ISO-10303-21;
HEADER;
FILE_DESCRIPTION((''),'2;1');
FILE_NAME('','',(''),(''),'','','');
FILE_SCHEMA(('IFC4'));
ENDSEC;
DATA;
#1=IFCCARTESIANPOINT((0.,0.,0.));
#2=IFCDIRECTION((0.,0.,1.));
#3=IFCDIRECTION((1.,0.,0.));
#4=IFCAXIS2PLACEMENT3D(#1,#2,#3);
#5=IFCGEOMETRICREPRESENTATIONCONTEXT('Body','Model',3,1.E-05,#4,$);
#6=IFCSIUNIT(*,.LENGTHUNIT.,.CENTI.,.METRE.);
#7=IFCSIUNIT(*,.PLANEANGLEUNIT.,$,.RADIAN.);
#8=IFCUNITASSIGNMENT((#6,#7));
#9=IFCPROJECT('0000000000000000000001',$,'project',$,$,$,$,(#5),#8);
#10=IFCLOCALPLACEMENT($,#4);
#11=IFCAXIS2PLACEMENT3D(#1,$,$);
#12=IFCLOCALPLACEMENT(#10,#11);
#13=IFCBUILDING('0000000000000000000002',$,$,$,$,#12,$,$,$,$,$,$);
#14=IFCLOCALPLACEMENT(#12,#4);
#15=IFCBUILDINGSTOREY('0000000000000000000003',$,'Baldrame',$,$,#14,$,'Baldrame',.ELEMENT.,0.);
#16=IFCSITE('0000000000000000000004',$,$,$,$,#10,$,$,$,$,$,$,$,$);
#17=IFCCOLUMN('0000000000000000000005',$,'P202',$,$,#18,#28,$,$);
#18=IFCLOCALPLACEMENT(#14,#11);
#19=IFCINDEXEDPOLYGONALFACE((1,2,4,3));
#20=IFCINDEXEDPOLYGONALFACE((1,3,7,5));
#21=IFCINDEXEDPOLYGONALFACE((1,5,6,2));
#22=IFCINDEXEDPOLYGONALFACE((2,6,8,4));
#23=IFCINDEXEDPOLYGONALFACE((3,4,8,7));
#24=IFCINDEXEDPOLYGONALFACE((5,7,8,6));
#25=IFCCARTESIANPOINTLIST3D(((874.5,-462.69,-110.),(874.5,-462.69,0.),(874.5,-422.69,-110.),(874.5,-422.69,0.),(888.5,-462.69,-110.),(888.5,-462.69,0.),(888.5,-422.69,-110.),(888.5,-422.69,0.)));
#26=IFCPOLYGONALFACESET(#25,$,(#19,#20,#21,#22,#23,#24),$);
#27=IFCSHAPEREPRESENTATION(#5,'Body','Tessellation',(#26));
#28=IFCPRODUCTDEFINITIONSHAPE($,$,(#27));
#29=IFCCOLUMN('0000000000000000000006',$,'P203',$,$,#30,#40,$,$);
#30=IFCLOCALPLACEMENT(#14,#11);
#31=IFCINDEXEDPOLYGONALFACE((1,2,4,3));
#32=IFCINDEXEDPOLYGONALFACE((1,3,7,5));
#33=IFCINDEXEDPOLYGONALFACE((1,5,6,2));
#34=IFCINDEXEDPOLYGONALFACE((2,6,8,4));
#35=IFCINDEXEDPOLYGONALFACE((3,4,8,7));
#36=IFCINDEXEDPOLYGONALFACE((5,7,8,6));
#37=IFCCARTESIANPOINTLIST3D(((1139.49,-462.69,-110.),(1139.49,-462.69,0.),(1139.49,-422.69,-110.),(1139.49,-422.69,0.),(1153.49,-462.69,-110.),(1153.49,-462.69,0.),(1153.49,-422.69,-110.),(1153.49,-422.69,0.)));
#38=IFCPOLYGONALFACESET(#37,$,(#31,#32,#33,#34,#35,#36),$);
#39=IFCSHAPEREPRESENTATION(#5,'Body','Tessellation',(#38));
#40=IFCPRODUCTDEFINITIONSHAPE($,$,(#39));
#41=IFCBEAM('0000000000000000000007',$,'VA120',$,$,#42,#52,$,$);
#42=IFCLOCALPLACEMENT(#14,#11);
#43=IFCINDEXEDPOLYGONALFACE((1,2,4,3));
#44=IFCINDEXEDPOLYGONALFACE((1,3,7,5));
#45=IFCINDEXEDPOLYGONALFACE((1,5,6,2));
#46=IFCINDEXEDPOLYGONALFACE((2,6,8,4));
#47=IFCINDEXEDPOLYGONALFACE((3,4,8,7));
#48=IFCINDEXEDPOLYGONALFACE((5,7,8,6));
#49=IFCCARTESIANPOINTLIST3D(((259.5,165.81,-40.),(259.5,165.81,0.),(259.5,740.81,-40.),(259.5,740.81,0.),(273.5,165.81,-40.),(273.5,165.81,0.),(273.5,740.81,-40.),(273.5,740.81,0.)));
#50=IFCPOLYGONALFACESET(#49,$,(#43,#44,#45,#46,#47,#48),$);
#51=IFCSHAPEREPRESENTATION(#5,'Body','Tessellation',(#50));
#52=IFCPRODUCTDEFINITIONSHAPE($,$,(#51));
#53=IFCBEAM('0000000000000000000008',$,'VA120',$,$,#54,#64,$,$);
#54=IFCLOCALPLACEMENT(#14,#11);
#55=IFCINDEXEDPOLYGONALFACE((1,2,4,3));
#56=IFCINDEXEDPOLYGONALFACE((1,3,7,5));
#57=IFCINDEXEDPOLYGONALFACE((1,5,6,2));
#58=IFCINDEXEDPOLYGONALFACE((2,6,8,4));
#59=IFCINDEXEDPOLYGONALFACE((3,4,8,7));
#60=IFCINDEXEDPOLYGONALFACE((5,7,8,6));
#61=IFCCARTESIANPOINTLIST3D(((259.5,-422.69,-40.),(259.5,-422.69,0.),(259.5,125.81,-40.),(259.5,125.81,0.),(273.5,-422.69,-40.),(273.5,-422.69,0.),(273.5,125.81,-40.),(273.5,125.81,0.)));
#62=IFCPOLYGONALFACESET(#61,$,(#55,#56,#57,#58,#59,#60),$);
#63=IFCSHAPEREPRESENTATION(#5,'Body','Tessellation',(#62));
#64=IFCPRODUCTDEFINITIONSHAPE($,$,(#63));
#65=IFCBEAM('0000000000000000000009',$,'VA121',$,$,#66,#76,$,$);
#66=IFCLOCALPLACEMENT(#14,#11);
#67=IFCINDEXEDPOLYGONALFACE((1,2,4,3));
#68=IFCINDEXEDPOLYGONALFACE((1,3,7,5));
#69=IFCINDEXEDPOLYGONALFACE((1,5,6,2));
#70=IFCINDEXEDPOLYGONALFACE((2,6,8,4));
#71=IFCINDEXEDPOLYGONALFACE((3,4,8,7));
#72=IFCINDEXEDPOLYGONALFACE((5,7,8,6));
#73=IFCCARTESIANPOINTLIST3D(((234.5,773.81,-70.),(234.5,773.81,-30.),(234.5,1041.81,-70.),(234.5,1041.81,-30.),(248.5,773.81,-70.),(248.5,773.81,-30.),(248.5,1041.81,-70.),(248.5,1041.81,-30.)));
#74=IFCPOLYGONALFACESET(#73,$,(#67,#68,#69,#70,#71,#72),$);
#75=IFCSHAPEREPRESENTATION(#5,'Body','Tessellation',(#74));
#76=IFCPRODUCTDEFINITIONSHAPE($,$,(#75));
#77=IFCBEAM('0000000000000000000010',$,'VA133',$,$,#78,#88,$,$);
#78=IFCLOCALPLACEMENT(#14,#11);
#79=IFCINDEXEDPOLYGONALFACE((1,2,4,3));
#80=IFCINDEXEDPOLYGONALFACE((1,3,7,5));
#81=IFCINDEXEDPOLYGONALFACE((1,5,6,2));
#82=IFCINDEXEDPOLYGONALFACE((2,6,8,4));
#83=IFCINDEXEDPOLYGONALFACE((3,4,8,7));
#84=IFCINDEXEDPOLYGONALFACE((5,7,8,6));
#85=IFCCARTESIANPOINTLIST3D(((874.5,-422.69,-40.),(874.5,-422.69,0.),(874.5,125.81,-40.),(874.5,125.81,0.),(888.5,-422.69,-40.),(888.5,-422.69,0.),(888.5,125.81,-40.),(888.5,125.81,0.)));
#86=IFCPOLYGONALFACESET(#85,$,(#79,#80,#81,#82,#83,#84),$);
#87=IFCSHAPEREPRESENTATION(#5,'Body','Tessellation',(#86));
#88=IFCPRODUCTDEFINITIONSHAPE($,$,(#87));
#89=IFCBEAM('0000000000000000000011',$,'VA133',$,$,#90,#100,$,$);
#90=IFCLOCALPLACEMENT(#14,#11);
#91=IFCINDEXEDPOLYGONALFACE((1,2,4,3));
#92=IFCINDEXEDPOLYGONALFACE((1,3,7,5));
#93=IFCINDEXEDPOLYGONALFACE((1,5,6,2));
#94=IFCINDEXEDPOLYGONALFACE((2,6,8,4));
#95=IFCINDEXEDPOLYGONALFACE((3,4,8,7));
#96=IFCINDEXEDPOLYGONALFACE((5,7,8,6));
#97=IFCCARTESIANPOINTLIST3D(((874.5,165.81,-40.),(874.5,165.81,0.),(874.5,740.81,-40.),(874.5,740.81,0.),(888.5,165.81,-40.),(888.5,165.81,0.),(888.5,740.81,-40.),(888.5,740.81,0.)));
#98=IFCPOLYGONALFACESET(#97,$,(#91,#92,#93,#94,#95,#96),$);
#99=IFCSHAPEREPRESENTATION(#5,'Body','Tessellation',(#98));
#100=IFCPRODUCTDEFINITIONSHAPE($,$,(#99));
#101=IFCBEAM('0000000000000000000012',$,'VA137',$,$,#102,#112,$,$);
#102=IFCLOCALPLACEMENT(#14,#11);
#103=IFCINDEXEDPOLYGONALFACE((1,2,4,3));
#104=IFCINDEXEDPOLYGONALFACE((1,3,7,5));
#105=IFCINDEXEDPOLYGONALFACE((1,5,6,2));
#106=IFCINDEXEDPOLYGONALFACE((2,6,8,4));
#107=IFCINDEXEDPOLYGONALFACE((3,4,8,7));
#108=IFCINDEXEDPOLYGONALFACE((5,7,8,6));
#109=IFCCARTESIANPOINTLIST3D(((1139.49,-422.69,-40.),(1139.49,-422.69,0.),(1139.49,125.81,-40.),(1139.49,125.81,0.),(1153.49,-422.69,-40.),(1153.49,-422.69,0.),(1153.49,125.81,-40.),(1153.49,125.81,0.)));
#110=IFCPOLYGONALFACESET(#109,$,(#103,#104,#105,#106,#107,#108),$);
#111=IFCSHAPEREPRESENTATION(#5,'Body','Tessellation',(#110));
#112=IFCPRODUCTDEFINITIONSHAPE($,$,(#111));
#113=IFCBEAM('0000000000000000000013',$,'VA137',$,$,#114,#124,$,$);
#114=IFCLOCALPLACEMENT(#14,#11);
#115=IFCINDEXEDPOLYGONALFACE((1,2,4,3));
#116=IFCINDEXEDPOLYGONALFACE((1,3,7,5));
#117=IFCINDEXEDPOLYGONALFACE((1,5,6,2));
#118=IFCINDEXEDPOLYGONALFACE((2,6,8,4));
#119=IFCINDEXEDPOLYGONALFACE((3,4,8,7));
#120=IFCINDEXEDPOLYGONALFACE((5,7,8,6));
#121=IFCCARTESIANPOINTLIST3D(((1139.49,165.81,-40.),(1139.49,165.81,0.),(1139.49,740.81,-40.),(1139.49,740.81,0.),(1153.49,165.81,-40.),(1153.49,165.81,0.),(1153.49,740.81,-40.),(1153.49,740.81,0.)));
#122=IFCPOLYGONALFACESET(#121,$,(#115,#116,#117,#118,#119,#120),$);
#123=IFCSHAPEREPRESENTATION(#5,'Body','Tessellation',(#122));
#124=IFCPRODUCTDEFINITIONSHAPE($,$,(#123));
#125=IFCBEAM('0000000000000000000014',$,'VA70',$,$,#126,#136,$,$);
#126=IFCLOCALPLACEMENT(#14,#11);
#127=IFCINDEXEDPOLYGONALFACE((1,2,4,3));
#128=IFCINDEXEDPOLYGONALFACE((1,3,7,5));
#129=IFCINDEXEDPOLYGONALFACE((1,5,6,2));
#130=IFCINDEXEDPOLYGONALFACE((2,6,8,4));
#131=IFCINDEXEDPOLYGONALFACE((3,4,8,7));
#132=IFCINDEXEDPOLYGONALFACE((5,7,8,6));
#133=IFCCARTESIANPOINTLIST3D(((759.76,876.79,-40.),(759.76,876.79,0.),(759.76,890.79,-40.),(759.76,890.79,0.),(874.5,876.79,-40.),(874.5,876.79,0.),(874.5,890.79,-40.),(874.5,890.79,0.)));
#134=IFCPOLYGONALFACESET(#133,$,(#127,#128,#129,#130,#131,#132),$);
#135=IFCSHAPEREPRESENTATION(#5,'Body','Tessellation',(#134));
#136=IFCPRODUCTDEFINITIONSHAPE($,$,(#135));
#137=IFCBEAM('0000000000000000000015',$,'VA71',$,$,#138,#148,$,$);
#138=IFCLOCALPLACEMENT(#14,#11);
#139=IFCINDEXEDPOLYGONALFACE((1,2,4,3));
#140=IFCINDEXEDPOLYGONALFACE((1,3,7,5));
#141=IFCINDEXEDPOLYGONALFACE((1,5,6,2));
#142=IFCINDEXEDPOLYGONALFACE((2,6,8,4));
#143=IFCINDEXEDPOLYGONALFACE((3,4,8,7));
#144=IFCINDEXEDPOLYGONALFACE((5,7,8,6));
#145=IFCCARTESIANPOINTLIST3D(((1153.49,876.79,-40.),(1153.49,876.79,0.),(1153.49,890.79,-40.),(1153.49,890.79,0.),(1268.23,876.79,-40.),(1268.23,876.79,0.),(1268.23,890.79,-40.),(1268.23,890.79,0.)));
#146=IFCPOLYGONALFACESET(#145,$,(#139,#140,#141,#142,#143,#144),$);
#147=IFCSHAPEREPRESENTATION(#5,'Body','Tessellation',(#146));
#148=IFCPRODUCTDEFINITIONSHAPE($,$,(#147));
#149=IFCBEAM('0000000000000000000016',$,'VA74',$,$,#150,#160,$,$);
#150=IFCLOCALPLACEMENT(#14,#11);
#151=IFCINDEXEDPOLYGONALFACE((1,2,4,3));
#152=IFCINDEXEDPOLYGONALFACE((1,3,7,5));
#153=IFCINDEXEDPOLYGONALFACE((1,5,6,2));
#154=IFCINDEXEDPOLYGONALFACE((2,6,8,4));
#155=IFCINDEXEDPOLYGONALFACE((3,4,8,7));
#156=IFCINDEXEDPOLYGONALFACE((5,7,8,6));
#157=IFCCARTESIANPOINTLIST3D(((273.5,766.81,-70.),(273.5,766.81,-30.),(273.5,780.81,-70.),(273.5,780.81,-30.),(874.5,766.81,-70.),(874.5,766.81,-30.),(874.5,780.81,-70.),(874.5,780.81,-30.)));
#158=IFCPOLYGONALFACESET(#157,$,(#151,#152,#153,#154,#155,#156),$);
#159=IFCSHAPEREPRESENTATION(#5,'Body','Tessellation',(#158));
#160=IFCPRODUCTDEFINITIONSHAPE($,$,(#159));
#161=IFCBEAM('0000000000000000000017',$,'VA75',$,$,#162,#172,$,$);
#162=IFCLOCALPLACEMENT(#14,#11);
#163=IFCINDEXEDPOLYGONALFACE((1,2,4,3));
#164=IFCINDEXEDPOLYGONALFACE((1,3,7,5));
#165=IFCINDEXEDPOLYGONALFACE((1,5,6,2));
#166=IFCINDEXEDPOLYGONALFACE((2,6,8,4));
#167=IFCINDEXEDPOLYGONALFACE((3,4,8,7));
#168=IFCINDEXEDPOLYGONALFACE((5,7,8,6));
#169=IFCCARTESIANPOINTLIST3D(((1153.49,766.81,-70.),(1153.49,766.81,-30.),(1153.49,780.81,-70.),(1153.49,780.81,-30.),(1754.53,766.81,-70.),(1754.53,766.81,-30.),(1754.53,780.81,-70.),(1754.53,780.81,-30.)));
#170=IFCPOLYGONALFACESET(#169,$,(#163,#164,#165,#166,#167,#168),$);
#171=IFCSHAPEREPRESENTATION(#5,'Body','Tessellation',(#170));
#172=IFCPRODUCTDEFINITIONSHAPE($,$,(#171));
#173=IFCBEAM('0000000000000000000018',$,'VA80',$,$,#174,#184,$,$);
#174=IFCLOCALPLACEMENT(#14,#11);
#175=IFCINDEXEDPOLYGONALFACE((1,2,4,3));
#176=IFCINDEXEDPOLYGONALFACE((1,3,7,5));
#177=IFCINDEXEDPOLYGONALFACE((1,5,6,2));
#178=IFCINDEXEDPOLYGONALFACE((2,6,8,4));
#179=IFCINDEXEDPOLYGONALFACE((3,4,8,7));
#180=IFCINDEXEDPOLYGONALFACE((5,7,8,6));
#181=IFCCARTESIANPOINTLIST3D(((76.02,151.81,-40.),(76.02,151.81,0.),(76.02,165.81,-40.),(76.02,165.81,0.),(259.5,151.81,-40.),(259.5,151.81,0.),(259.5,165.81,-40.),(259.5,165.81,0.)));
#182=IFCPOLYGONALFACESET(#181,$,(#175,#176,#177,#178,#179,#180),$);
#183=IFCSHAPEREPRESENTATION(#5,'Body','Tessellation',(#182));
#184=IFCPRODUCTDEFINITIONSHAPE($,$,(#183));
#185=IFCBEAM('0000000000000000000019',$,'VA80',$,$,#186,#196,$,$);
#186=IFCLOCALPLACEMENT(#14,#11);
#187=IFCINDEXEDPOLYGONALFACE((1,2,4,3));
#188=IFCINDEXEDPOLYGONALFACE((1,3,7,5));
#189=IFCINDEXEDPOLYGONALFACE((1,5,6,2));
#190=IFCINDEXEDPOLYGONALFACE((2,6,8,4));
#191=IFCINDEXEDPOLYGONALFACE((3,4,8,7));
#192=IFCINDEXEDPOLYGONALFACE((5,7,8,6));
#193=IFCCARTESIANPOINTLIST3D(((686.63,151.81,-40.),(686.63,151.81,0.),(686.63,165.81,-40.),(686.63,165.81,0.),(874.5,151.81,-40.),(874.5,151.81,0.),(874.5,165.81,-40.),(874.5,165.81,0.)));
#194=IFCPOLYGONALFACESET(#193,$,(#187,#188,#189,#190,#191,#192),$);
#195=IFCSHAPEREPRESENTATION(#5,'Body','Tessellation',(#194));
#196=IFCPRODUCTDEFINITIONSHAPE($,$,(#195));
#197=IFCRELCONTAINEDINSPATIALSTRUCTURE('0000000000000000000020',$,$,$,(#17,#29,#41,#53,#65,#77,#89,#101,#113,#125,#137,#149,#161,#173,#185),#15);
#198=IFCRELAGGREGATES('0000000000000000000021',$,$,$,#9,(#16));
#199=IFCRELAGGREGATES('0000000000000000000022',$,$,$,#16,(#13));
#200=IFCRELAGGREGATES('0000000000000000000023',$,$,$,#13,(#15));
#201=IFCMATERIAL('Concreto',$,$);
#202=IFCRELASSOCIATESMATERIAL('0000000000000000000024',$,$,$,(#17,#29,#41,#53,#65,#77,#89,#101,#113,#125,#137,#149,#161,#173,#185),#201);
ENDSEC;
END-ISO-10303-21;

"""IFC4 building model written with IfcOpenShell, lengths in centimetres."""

from ifc_helpers import new_model, si_unit, frame, origin, origin_with_axes, origin_2d_with_axis, place, context, project, spatial, rectangle, extrude, material, element, save


model = new_model("IFC4")

# Units and contexts
model_context = context("Model", 3, precision=1e-05, world=origin_with_axes(), identifier="Body")
ifc_project = project(units=[si_unit("LENGTHUNIT", "METRE", prefix="CENTI"), si_unit("PLANEANGLEUNIT", "RADIAN")], contexts=[model_context])

# Site, building, storey
site_placement = place(None, origin_with_axes())
site = spatial("IfcSite", under=ifc_project, at=site_placement)
building_placement = place(site_placement, origin())
building = spatial("IfcBuilding", under=site, at=building_placement)
storey_placement = place(building_placement, origin_with_axes())
storey = spatial("IfcBuildingStorey", under=building, at=storey_placement, Name="Baldrame", LongName="Baldrame", CompositionType="ELEMENT", Elevation=0.0)

# Shared definitions
ifc_material = material(Name="Concreto")

# Columns
for number, where, z_axis, x_axis, name in (
    (1, (881.5, -442.69, 0.0), (0.0, 0.0, 1.0), (1.0, 0.0, 0.0), "P202"),
    (2, (1146.49, -442.69, 0.0), (0.0, 0.0, 1.0), (1.0, 0.0, 0.0), "P203"),
):
    element("IfcColumn", number, at=place(storey_placement, frame(where, z_axis=z_axis, x_axis=x_axis)), inside=storey, material=ifc_material, Name=name, context=model_context, shape_type="SolidModel", body=[
        extrude(rectangle(XDim=14.0, YDim=40.0, at=origin_2d_with_axis()), frame((0.0, 0.0, -110.0), z_axis=(0.0, 0.0, 1.0), x_axis=(1.0, 0.0, 0.0)), (0.0, 0.0, 1.0), 110.0),
    ])

# Beams
beam_1_placement = place(storey_placement, frame((266.5, 453.31, 0.0), z_axis=(0.0, 0.0, 1.0), x_axis=(1.0, 0.0, 0.0)))
element("IfcBeam", 3, at=beam_1_placement, inside=storey, material=ifc_material, Name="VA120", context=model_context, shape_type="SolidModel", body=[
    extrude(rectangle(XDim=14.0, YDim=40.0, at=origin_2d_with_axis()), frame((0.0, -287.5, -20.0), z_axis=(0.0, 1.0, 0.0), x_axis=(1.0, 0.0, 0.0)), (0.0, 0.0, 1.0), 575.0),
])
beam_2_placement = place(storey_placement, frame((266.5, -148.44, 0.0), z_axis=(0.0, 0.0, 1.0), x_axis=(1.0, 0.0, 0.0)))
element("IfcBeam", 4, at=beam_2_placement, inside=storey, material=ifc_material, Name="VA120", context=model_context, shape_type="SolidModel", body=[
    extrude(rectangle(XDim=14.0, YDim=40.0, at=origin_2d_with_axis()), frame((0.0, -274.25, -20.0), z_axis=(0.0, 1.0, 0.0), x_axis=(1.0, 0.0, 0.0)), (0.0, 0.0, 1.0), 548.5),
])
beam_3_placement = place(storey_placement, frame((241.5, 907.81, -30.0), z_axis=(0.0, 0.0, 1.0), x_axis=(1.0, 0.0, 0.0)))
element("IfcBeam", 5, at=beam_3_placement, inside=storey, material=ifc_material, Name="VA121", context=model_context, shape_type="SolidModel", body=[
    extrude(rectangle(XDim=14.0, YDim=40.0, at=origin_2d_with_axis()), frame((0.0, -134.0, -20.0), z_axis=(0.0, 1.0, 0.0), x_axis=(-1.0, 0.0, 0.0)), (0.0, 0.0, 1.0), 268.0),
])
beam_4_placement = place(storey_placement, frame((881.5, -148.44, 0.0), z_axis=(0.0, 0.0, 1.0), x_axis=(1.0, 0.0, 0.0)))
element("IfcBeam", 6, at=beam_4_placement, inside=storey, material=ifc_material, Name="VA133", context=model_context, shape_type="SolidModel", body=[
    extrude(rectangle(XDim=14.0, YDim=40.0, at=origin_2d_with_axis()), frame((0.0, -274.25, -20.0), z_axis=(0.0, 1.0, 0.0), x_axis=(1.0, 0.0, 0.0)), (0.0, 0.0, 1.0), 548.5),
])
beam_5_placement = place(storey_placement, frame((881.5, 453.31, 0.0), z_axis=(0.0, 0.0, 1.0), x_axis=(1.0, 0.0, 0.0)))
element("IfcBeam", 7, at=beam_5_placement, inside=storey, material=ifc_material, Name="VA133", context=model_context, shape_type="SolidModel", body=[
    extrude(rectangle(XDim=14.0, YDim=40.0, at=origin_2d_with_axis()), frame((0.0, -287.5, -20.0), z_axis=(0.0, 1.0, 0.0), x_axis=(1.0, 0.0, 0.0)), (0.0, 0.0, 1.0), 575.0),
])
beam_6_placement = place(storey_placement, frame((1146.49, -148.44, 0.0), z_axis=(0.0, 0.0, 1.0), x_axis=(1.0, 0.0, 0.0)))
element("IfcBeam", 8, at=beam_6_placement, inside=storey, material=ifc_material, Name="VA137", context=model_context, shape_type="SolidModel", body=[
    extrude(rectangle(XDim=14.0, YDim=40.0, at=origin_2d_with_axis()), frame((0.0, -274.25, -20.0), z_axis=(0.0, 1.0, 0.0), x_axis=(1.0, 0.0, 0.0)), (0.0, 0.0, 1.0), 548.5),
])
beam_7_placement = place(storey_placement, frame((1146.49, 453.31, 0.0), z_axis=(0.0, 0.0, 1.0), x_axis=(1.0, 0.0, 0.0)))
element("IfcBeam", 9, at=beam_7_placement, inside=storey, material=ifc_material, Name="VA137", context=model_context, shape_type="SolidModel", body=[
    extrude(rectangle(XDim=14.0, YDim=40.0, at=origin_2d_with_axis()), frame((0.0, -287.5, -20.0), z_axis=(0.0, 1.0, 0.0), x_axis=(1.0, 0.0, 0.0)), (0.0, 0.0, 1.0), 575.0),
])
beam_8_placement = place(storey_placement, frame((817.13, 883.79, 0.0), z_axis=(0.0, 0.0, 1.0), x_axis=(1.0, 0.0, 0.0)))
element("IfcBeam", 10, at=beam_8_placement, inside=storey, material=ifc_material, Name="VA70", context=model_context, shape_type="SolidModel", body=[
    extrude(rectangle(XDim=14.0, YDim=40.0, at=origin_2d_with_axis()), frame((-57.37, 0.0, -20.0), z_axis=(1.0, 0.0, 0.0), x_axis=(0.0, 1.0, 0.0)), (0.0, 0.0, 1.0), 114.74),
])
beam_9_placement = place(storey_placement, frame((1210.86, 883.79, 0.0), z_axis=(0.0, 0.0, 1.0), x_axis=(1.0, 0.0, 0.0)))
element("IfcBeam", 11, at=beam_9_placement, inside=storey, material=ifc_material, Name="VA71", context=model_context, shape_type="SolidModel", body=[
    extrude(rectangle(XDim=14.0, YDim=40.0, at=origin_2d_with_axis()), frame((-57.37, 0.0, -20.0), z_axis=(1.0, 0.0, 0.0), x_axis=(0.0, 1.0, 0.0)), (0.0, 0.0, 1.0), 114.74),
])
beam_10_placement = place(storey_placement, frame((574.0, 773.81, -30.0), z_axis=(0.0, 0.0, 1.0), x_axis=(1.0, 0.0, 0.0)))
element("IfcBeam", 12, at=beam_10_placement, inside=storey, material=ifc_material, Name="VA74", context=model_context, shape_type="SolidModel", body=[
    extrude(rectangle(XDim=14.0, YDim=40.0, at=origin_2d_with_axis()), frame((-300.5, 0.0, -20.0), z_axis=(1.0, 0.0, 0.0), x_axis=(0.0, 1.0, 0.0)), (0.0, 0.0, 1.0), 601.0),
])
beam_11_placement = place(storey_placement, frame((1454.01, 773.81, -30.0), z_axis=(0.0, 0.0, 1.0), x_axis=(1.0, 0.0, 0.0)))
element("IfcBeam", 13, at=beam_11_placement, inside=storey, material=ifc_material, Name="VA75", context=model_context, shape_type="SolidModel", body=[
    extrude(rectangle(XDim=14.0, YDim=40.0, at=origin_2d_with_axis()), frame((-300.52, 0.0, -20.0), z_axis=(1.0, 0.0, 0.0), x_axis=(0.0, 1.0, 0.0)), (0.0, 0.0, 1.0), 601.04),
])
beam_12_placement = place(storey_placement, frame((167.76, 158.81, 0.0), z_axis=(0.0, 0.0, 1.0), x_axis=(1.0, 0.0, 0.0)))
element("IfcBeam", 14, at=beam_12_placement, inside=storey, material=ifc_material, Name="VA80", context=model_context, shape_type="SolidModel", body=[
    extrude(rectangle(XDim=14.0, YDim=40.0, at=origin_2d_with_axis()), frame((-91.74, 0.0, -20.0), z_axis=(1.0, 0.0, 0.0), x_axis=(0.0, 1.0, 0.0)), (0.0, 0.0, 1.0), 183.48),
])
beam_13_placement = place(storey_placement, frame((780.57, 158.81, 0.0), z_axis=(0.0, 0.0, 1.0), x_axis=(1.0, 0.0, 0.0)))
element("IfcBeam", 15, at=beam_13_placement, inside=storey, material=ifc_material, Name="VA80", context=model_context, shape_type="SolidModel", body=[
    extrude(rectangle(XDim=14.0, YDim=40.0, at=origin_2d_with_axis()), frame((-93.94, 0.0, -20.0), z_axis=(1.0, 0.0, 0.0), x_axis=(0.0, 1.0, 0.0)), (0.0, 0.0, 1.0), 187.87),
])

save(model, "model.ifc")
